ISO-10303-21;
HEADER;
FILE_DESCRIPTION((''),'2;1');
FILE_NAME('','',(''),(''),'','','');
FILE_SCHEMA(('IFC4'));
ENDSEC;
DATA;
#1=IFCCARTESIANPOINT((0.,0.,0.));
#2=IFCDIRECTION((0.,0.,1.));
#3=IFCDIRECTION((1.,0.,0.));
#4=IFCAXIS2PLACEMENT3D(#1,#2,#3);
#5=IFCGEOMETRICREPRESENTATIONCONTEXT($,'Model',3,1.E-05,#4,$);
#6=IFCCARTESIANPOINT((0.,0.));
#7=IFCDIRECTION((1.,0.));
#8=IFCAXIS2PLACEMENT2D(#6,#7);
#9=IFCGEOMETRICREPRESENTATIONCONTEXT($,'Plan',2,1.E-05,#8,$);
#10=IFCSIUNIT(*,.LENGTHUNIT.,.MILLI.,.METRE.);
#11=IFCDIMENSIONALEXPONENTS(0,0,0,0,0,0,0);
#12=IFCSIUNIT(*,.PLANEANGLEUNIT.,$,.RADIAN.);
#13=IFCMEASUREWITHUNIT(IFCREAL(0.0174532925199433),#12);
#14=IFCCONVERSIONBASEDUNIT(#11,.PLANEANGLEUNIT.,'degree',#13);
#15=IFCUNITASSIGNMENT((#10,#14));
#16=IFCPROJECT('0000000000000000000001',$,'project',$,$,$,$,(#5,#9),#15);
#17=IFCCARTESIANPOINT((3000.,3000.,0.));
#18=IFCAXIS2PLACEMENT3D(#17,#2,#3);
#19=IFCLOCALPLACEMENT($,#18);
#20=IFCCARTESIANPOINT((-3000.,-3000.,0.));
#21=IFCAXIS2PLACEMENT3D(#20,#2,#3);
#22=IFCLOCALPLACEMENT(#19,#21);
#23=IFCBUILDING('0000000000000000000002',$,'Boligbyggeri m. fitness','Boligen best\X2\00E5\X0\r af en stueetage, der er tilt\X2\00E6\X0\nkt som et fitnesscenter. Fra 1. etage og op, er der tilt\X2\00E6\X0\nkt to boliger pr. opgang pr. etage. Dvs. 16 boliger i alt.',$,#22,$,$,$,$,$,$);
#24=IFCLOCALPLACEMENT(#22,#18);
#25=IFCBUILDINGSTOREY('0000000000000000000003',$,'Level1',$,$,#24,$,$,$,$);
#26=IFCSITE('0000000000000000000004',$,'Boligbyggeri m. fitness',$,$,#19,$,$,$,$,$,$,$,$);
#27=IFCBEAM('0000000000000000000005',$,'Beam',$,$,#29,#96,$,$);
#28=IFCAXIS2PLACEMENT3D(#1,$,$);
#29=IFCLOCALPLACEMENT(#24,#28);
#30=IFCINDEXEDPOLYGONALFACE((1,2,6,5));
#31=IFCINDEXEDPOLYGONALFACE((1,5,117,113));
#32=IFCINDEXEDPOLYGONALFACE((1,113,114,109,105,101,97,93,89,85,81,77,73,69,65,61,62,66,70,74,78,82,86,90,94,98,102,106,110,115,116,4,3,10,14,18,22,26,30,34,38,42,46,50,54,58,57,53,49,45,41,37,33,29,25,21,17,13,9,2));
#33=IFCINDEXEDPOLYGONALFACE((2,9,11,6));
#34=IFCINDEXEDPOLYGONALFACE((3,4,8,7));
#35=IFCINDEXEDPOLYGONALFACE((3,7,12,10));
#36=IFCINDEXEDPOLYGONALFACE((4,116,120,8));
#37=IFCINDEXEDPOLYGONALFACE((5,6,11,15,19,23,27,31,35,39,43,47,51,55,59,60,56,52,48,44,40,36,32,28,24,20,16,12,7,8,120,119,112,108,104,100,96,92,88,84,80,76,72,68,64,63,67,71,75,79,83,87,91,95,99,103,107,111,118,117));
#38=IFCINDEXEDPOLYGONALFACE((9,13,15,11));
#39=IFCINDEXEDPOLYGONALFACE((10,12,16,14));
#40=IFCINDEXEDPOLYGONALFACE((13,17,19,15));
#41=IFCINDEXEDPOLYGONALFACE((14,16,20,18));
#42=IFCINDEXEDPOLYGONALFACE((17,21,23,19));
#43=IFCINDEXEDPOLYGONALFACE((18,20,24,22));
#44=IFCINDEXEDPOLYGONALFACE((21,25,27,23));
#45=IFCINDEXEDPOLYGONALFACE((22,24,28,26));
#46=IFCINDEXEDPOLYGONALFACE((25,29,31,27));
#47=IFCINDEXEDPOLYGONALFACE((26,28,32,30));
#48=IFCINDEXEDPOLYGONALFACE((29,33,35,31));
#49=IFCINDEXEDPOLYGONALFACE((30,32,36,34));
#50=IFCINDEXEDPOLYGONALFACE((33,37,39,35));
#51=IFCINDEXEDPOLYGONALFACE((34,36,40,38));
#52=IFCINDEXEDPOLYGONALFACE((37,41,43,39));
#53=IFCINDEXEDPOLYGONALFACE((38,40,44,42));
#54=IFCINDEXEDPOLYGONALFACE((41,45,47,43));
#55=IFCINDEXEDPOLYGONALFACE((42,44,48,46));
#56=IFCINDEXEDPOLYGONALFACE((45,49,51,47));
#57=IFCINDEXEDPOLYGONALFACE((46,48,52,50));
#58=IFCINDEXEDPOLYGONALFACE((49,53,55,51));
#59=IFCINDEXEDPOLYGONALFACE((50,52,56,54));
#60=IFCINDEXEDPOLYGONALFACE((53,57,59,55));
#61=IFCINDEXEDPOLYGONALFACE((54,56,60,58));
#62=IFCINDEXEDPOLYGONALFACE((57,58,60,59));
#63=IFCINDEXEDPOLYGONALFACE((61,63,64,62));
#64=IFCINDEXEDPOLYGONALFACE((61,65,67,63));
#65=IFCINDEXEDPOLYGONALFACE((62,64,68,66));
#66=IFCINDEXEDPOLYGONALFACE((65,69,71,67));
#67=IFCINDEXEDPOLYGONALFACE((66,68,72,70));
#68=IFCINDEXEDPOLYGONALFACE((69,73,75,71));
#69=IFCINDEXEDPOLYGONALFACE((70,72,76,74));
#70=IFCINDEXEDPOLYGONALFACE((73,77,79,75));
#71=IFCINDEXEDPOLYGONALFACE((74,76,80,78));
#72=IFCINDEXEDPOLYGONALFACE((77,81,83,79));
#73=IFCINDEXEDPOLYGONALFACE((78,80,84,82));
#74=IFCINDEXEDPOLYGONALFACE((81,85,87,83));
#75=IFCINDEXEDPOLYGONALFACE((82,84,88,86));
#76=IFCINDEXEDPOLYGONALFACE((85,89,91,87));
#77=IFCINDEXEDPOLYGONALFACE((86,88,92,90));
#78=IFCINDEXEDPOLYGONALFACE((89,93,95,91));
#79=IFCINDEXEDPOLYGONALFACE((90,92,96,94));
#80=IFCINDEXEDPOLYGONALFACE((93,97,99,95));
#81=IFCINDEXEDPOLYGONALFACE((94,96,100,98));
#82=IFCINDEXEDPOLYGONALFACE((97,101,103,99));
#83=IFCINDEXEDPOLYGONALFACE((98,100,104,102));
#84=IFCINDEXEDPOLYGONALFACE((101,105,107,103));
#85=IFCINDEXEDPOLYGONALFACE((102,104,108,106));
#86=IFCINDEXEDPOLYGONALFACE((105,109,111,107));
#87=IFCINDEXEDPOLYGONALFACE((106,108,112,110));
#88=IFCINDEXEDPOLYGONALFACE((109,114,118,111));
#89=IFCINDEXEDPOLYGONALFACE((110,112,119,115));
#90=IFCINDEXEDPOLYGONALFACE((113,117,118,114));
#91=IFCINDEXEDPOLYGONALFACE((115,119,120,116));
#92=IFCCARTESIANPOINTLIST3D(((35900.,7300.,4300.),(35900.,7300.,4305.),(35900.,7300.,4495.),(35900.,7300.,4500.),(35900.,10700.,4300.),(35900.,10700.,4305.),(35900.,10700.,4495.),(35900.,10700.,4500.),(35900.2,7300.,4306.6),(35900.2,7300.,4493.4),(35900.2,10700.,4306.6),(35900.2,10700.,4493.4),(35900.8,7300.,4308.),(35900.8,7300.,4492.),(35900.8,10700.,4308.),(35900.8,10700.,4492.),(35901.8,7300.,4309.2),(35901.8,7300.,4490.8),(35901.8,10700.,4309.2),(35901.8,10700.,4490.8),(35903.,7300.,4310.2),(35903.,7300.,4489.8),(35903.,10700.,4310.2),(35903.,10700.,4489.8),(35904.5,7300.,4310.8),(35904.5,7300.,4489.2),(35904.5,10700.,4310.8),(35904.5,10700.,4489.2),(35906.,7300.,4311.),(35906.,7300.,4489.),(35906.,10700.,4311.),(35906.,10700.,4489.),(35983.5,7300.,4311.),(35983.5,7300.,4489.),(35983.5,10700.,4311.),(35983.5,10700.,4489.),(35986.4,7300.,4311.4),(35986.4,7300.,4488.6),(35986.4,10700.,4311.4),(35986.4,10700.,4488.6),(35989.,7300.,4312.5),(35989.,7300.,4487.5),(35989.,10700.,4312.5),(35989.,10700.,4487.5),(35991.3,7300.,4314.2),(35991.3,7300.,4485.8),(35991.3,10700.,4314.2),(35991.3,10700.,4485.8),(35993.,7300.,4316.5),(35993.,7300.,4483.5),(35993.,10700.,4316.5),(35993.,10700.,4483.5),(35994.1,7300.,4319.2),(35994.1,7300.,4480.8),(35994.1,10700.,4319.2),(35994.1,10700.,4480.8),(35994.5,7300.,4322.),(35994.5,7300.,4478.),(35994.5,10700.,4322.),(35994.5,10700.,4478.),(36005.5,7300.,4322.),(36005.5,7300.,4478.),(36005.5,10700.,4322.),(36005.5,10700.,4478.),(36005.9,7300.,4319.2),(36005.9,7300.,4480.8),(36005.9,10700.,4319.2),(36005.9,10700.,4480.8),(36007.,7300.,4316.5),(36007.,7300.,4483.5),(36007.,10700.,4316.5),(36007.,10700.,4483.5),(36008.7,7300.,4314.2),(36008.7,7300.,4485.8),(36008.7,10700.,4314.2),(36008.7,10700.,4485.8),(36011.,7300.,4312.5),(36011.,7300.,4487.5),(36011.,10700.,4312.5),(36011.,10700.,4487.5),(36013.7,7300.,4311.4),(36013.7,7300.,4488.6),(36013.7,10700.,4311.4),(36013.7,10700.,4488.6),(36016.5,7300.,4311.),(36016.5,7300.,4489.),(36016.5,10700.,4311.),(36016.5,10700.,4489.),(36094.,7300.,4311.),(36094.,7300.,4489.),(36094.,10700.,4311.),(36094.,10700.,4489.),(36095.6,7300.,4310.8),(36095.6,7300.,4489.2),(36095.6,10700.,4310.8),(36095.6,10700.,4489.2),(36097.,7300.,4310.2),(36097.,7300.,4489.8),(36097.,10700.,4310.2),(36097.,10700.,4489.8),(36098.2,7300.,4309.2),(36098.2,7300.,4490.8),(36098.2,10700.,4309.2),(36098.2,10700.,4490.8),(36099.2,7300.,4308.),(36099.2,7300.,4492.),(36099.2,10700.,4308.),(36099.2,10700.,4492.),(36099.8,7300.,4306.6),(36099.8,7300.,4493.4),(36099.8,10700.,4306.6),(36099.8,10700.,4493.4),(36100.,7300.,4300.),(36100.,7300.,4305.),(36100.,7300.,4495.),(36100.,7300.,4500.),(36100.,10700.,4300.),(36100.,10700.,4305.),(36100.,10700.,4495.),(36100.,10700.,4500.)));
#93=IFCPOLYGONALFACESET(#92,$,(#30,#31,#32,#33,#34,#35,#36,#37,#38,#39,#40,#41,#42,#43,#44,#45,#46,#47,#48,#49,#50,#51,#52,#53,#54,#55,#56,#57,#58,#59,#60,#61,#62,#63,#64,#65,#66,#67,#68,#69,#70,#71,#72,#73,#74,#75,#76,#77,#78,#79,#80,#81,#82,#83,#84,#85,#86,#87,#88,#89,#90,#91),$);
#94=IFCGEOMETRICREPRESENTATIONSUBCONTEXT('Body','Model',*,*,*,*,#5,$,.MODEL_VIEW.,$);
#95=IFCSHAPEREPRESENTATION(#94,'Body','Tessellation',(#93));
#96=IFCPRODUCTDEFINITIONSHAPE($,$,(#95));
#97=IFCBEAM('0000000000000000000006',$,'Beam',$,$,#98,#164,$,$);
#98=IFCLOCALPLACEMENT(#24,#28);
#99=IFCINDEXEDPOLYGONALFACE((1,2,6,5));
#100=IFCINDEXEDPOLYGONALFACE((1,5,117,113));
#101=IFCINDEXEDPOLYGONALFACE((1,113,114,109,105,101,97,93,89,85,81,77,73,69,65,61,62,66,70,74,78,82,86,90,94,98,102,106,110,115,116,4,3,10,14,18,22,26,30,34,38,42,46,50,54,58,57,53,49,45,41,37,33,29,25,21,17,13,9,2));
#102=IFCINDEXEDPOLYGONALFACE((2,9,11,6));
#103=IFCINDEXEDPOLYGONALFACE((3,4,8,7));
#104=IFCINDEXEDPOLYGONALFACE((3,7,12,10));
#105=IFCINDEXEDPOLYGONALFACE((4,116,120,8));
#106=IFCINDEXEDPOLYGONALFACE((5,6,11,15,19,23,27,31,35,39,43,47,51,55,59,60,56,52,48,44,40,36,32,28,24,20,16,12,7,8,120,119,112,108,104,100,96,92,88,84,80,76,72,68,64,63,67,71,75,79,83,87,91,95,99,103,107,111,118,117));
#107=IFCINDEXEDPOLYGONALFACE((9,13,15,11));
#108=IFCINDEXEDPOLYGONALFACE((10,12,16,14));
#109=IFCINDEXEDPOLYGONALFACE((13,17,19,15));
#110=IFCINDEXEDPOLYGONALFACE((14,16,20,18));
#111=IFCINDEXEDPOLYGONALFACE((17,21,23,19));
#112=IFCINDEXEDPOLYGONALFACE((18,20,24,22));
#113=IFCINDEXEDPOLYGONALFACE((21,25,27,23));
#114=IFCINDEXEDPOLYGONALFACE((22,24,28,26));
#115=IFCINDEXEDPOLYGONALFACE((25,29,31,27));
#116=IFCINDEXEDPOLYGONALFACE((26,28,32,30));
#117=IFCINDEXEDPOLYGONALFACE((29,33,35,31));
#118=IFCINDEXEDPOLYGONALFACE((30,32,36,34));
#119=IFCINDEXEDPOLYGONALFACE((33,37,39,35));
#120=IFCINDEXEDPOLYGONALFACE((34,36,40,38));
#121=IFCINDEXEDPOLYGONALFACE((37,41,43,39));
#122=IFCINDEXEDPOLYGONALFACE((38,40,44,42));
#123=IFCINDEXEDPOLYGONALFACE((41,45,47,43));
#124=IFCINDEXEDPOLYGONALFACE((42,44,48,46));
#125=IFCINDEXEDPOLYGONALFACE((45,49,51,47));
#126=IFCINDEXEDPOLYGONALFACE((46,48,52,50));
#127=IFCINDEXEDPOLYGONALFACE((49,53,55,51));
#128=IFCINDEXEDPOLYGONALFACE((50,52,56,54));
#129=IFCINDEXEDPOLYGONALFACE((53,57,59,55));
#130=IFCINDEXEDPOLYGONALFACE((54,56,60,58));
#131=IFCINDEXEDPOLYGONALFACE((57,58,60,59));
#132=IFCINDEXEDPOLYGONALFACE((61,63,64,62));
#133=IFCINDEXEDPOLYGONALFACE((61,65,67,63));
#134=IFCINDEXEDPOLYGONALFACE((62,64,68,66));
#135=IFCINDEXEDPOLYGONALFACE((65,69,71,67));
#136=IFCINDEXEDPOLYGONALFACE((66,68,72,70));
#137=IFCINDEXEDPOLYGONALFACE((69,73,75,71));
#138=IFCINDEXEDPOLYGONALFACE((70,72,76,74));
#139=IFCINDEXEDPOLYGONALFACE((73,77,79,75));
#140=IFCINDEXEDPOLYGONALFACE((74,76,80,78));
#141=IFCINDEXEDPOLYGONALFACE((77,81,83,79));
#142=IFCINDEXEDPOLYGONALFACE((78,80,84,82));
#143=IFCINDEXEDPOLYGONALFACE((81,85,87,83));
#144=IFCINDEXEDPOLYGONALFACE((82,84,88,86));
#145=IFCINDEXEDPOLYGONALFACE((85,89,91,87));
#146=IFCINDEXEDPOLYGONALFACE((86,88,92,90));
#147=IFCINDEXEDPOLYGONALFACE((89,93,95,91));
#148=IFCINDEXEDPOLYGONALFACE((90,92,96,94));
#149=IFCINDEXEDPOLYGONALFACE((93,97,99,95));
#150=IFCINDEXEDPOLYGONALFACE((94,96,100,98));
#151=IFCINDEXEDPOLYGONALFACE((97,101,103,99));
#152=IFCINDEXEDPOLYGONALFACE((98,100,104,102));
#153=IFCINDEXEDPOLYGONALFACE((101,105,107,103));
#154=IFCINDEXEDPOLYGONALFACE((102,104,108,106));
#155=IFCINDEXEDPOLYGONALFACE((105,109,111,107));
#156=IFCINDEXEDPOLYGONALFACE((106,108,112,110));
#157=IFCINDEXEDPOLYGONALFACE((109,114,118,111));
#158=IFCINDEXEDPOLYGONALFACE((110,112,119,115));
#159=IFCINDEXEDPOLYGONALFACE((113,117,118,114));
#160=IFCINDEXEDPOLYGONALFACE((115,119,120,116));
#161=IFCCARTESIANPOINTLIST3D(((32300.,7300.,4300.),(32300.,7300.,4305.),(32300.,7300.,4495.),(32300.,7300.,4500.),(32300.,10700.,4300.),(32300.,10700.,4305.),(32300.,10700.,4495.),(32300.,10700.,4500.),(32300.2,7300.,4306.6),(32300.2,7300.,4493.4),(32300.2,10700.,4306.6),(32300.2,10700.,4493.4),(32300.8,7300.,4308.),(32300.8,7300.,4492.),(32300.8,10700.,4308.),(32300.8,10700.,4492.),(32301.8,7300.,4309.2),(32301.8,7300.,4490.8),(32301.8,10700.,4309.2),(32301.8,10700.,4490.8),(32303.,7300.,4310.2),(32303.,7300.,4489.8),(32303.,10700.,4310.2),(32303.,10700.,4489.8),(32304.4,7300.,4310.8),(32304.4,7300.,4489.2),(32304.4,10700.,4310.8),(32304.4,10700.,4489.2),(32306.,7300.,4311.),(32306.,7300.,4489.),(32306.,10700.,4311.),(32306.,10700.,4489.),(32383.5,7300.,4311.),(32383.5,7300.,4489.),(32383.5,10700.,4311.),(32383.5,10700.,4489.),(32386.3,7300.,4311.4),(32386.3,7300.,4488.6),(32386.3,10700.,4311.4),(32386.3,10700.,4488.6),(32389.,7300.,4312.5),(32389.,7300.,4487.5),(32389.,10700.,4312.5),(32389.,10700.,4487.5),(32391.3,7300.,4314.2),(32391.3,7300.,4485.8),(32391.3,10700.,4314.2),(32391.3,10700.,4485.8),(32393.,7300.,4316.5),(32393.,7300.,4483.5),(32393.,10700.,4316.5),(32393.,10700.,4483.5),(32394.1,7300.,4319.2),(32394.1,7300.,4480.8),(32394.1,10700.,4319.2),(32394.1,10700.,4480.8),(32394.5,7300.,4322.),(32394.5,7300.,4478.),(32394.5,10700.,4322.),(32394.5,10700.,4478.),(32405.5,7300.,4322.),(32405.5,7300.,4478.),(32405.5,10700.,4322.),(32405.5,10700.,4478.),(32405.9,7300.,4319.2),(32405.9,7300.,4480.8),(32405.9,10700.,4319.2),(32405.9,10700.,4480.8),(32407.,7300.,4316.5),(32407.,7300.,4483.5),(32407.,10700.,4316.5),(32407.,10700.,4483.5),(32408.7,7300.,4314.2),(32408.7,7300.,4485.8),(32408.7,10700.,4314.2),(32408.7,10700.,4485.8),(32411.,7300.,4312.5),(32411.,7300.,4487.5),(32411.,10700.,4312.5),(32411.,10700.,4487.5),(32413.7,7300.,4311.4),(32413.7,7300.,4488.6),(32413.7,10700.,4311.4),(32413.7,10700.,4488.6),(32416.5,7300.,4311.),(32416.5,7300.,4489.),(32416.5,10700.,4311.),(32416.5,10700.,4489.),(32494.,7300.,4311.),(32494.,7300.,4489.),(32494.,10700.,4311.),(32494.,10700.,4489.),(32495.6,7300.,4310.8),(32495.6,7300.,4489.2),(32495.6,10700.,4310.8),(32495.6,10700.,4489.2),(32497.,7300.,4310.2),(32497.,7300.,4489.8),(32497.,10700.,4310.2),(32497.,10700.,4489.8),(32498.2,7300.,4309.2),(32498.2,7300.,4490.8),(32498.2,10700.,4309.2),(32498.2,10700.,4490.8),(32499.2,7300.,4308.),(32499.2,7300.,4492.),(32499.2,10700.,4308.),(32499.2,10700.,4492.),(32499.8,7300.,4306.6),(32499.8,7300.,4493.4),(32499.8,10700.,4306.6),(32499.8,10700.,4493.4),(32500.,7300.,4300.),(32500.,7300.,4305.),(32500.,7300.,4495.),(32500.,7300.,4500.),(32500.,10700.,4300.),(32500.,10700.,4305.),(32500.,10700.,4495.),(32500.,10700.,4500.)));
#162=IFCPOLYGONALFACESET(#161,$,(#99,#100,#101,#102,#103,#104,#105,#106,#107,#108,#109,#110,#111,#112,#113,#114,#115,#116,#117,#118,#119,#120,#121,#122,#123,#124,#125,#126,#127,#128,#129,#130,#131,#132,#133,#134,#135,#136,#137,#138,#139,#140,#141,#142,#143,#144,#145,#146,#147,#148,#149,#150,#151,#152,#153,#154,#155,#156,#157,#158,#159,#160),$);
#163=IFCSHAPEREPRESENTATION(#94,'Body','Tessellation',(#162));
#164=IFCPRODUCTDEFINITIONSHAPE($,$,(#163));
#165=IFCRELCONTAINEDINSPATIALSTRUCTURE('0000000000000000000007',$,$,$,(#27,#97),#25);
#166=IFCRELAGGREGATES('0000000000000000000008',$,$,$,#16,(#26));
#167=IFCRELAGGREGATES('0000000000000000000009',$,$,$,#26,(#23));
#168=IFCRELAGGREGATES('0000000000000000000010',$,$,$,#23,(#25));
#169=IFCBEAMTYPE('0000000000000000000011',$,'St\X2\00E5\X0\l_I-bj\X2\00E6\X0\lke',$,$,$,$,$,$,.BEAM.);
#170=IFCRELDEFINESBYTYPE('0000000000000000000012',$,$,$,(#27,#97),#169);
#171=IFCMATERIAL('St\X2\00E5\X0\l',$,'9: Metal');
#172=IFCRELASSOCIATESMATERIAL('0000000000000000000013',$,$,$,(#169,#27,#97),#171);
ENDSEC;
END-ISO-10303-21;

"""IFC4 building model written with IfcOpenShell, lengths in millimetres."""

from ifc_helpers import new_model, entity, si_unit, converted_unit, frame, origin_with_axes, origin_2d_with_axis, place, context, subcontext, project, spatial, i_section, extrude, material, material_profile, profile_set, profile_usage, type_object, element, save


model = new_model("IFC4")

# Units and contexts
model_context = context("Model", 3, precision=1e-05, world=origin_with_axes())
plan_context = context("Plan", 2, precision=1e-05, world=origin_2d_with_axis())
body_context = subcontext(model_context, "Body", "Model", "MODEL_VIEW")
ifc_project = project(units=[si_unit("LENGTHUNIT", "METRE", prefix="MILLI"), converted_unit("PLANEANGLEUNIT", "degree", entity("IfcReal", 0.0174532925199433), si_unit("PLANEANGLEUNIT", "RADIAN"), dimensions=[0, 0, 0, 0, 0, 0, 0])], contexts=[model_context, plan_context])

# Site, building, storey
site_placement = place(None, frame((3000.0, 3000.0, 0.0), z_axis=(0.0, 0.0, 1.0), x_axis=(1.0, 0.0, 0.0)))
site = spatial("IfcSite", under=ifc_project, at=site_placement, Name="Boligbyggeri m. fitness")
building_placement = place(site_placement, frame((-3000.0, -3000.0, 0.0), z_axis=(0.0, 0.0, 1.0), x_axis=(1.0, 0.0, 0.0)))
building = spatial("IfcBuilding", under=site, at=building_placement, Name="Boligbyggeri m. fitness", Description="Boligen består af en stueetage, der er tiltænkt som et fitnesscenter. Fra 1. etage og op, er der tiltænkt to boliger pr. opgang pr. etage. Dvs. 16 boliger i alt.")
storey_placement = place(building_placement, frame((3000.0, 3000.0, 0.0), z_axis=(0.0, 0.0, 1.0), x_axis=(1.0, 0.0, 0.0)))
storey = spatial("IfcBuildingStorey", under=building, at=storey_placement, Name="Level1")

# Beams
ifc_material_1 = material(Name="Stål", Category="9: Metal")
ifc_material_profile_1 = material_profile(ifc_material_1, i_section(OverallWidth=200.0, OverallDepth=200.0, WebThickness=11.0, FlangeThickness=11.0, FilletRadius=11.0, FlangeEdgeRadius=6.0), Name="Stål", Category="9: Metal")
ifc_profile_set_1 = profile_set([ifc_material_profile_1], Name="NY_I-Profil")
beam_type = type_object("IfcBeamType", Name="Stål_I-bjælke", PredefinedType="BEAM", material=ifc_profile_set_1)
ifc_profile_usage_1 = profile_usage(ifc_profile_set_1, cardinal=9)
beam_1_placement = place(storey_placement, frame((36100.0, 7300.0, 4500.0), z_axis=(0.0, 1.0, 0.0), x_axis=(-1.0, 0.0, 0.0)))
element("IfcBeam", 1, at=beam_1_placement, inside=storey, type_object=beam_type, material=ifc_profile_usage_1, Name="Beam", context=body_context, shape_type="SweptSolid", body=[
    extrude(i_section(OverallWidth=200.0, OverallDepth=200.0, WebThickness=11.0, FlangeThickness=11.0, FilletRadius=11.0, FlangeEdgeRadius=6.0), frame((100.0, -100.0, 0.0), z_axis=(0.0, 0.0, 1.0), x_axis=(1.0, 0.0, 0.0)), (0.0, 0.0, 1.0), 3400.0),
])
ifc_profile_usage_2 = profile_usage(ifc_profile_set_1, cardinal=9)
beam_2_placement = place(storey_placement, frame((32500.0, 7300.0, 4500.0), z_axis=(0.0, 1.0, 0.0), x_axis=(-1.0, 0.0, 0.0)))
element("IfcBeam", 2, at=beam_2_placement, inside=storey, type_object=beam_type, material=ifc_profile_usage_2, Name="Beam", context=body_context, shape_type="SweptSolid", body=[
    extrude(i_section(OverallWidth=200.0, OverallDepth=200.0, WebThickness=11.0, FlangeThickness=11.0, FilletRadius=11.0, FlangeEdgeRadius=6.0), frame((100.0, -100.0, 0.0), z_axis=(0.0, 0.0, 1.0), x_axis=(1.0, 0.0, 0.0)), (0.0, 0.0, 1.0), 3400.0),
])

save(model, "model.ifc")
